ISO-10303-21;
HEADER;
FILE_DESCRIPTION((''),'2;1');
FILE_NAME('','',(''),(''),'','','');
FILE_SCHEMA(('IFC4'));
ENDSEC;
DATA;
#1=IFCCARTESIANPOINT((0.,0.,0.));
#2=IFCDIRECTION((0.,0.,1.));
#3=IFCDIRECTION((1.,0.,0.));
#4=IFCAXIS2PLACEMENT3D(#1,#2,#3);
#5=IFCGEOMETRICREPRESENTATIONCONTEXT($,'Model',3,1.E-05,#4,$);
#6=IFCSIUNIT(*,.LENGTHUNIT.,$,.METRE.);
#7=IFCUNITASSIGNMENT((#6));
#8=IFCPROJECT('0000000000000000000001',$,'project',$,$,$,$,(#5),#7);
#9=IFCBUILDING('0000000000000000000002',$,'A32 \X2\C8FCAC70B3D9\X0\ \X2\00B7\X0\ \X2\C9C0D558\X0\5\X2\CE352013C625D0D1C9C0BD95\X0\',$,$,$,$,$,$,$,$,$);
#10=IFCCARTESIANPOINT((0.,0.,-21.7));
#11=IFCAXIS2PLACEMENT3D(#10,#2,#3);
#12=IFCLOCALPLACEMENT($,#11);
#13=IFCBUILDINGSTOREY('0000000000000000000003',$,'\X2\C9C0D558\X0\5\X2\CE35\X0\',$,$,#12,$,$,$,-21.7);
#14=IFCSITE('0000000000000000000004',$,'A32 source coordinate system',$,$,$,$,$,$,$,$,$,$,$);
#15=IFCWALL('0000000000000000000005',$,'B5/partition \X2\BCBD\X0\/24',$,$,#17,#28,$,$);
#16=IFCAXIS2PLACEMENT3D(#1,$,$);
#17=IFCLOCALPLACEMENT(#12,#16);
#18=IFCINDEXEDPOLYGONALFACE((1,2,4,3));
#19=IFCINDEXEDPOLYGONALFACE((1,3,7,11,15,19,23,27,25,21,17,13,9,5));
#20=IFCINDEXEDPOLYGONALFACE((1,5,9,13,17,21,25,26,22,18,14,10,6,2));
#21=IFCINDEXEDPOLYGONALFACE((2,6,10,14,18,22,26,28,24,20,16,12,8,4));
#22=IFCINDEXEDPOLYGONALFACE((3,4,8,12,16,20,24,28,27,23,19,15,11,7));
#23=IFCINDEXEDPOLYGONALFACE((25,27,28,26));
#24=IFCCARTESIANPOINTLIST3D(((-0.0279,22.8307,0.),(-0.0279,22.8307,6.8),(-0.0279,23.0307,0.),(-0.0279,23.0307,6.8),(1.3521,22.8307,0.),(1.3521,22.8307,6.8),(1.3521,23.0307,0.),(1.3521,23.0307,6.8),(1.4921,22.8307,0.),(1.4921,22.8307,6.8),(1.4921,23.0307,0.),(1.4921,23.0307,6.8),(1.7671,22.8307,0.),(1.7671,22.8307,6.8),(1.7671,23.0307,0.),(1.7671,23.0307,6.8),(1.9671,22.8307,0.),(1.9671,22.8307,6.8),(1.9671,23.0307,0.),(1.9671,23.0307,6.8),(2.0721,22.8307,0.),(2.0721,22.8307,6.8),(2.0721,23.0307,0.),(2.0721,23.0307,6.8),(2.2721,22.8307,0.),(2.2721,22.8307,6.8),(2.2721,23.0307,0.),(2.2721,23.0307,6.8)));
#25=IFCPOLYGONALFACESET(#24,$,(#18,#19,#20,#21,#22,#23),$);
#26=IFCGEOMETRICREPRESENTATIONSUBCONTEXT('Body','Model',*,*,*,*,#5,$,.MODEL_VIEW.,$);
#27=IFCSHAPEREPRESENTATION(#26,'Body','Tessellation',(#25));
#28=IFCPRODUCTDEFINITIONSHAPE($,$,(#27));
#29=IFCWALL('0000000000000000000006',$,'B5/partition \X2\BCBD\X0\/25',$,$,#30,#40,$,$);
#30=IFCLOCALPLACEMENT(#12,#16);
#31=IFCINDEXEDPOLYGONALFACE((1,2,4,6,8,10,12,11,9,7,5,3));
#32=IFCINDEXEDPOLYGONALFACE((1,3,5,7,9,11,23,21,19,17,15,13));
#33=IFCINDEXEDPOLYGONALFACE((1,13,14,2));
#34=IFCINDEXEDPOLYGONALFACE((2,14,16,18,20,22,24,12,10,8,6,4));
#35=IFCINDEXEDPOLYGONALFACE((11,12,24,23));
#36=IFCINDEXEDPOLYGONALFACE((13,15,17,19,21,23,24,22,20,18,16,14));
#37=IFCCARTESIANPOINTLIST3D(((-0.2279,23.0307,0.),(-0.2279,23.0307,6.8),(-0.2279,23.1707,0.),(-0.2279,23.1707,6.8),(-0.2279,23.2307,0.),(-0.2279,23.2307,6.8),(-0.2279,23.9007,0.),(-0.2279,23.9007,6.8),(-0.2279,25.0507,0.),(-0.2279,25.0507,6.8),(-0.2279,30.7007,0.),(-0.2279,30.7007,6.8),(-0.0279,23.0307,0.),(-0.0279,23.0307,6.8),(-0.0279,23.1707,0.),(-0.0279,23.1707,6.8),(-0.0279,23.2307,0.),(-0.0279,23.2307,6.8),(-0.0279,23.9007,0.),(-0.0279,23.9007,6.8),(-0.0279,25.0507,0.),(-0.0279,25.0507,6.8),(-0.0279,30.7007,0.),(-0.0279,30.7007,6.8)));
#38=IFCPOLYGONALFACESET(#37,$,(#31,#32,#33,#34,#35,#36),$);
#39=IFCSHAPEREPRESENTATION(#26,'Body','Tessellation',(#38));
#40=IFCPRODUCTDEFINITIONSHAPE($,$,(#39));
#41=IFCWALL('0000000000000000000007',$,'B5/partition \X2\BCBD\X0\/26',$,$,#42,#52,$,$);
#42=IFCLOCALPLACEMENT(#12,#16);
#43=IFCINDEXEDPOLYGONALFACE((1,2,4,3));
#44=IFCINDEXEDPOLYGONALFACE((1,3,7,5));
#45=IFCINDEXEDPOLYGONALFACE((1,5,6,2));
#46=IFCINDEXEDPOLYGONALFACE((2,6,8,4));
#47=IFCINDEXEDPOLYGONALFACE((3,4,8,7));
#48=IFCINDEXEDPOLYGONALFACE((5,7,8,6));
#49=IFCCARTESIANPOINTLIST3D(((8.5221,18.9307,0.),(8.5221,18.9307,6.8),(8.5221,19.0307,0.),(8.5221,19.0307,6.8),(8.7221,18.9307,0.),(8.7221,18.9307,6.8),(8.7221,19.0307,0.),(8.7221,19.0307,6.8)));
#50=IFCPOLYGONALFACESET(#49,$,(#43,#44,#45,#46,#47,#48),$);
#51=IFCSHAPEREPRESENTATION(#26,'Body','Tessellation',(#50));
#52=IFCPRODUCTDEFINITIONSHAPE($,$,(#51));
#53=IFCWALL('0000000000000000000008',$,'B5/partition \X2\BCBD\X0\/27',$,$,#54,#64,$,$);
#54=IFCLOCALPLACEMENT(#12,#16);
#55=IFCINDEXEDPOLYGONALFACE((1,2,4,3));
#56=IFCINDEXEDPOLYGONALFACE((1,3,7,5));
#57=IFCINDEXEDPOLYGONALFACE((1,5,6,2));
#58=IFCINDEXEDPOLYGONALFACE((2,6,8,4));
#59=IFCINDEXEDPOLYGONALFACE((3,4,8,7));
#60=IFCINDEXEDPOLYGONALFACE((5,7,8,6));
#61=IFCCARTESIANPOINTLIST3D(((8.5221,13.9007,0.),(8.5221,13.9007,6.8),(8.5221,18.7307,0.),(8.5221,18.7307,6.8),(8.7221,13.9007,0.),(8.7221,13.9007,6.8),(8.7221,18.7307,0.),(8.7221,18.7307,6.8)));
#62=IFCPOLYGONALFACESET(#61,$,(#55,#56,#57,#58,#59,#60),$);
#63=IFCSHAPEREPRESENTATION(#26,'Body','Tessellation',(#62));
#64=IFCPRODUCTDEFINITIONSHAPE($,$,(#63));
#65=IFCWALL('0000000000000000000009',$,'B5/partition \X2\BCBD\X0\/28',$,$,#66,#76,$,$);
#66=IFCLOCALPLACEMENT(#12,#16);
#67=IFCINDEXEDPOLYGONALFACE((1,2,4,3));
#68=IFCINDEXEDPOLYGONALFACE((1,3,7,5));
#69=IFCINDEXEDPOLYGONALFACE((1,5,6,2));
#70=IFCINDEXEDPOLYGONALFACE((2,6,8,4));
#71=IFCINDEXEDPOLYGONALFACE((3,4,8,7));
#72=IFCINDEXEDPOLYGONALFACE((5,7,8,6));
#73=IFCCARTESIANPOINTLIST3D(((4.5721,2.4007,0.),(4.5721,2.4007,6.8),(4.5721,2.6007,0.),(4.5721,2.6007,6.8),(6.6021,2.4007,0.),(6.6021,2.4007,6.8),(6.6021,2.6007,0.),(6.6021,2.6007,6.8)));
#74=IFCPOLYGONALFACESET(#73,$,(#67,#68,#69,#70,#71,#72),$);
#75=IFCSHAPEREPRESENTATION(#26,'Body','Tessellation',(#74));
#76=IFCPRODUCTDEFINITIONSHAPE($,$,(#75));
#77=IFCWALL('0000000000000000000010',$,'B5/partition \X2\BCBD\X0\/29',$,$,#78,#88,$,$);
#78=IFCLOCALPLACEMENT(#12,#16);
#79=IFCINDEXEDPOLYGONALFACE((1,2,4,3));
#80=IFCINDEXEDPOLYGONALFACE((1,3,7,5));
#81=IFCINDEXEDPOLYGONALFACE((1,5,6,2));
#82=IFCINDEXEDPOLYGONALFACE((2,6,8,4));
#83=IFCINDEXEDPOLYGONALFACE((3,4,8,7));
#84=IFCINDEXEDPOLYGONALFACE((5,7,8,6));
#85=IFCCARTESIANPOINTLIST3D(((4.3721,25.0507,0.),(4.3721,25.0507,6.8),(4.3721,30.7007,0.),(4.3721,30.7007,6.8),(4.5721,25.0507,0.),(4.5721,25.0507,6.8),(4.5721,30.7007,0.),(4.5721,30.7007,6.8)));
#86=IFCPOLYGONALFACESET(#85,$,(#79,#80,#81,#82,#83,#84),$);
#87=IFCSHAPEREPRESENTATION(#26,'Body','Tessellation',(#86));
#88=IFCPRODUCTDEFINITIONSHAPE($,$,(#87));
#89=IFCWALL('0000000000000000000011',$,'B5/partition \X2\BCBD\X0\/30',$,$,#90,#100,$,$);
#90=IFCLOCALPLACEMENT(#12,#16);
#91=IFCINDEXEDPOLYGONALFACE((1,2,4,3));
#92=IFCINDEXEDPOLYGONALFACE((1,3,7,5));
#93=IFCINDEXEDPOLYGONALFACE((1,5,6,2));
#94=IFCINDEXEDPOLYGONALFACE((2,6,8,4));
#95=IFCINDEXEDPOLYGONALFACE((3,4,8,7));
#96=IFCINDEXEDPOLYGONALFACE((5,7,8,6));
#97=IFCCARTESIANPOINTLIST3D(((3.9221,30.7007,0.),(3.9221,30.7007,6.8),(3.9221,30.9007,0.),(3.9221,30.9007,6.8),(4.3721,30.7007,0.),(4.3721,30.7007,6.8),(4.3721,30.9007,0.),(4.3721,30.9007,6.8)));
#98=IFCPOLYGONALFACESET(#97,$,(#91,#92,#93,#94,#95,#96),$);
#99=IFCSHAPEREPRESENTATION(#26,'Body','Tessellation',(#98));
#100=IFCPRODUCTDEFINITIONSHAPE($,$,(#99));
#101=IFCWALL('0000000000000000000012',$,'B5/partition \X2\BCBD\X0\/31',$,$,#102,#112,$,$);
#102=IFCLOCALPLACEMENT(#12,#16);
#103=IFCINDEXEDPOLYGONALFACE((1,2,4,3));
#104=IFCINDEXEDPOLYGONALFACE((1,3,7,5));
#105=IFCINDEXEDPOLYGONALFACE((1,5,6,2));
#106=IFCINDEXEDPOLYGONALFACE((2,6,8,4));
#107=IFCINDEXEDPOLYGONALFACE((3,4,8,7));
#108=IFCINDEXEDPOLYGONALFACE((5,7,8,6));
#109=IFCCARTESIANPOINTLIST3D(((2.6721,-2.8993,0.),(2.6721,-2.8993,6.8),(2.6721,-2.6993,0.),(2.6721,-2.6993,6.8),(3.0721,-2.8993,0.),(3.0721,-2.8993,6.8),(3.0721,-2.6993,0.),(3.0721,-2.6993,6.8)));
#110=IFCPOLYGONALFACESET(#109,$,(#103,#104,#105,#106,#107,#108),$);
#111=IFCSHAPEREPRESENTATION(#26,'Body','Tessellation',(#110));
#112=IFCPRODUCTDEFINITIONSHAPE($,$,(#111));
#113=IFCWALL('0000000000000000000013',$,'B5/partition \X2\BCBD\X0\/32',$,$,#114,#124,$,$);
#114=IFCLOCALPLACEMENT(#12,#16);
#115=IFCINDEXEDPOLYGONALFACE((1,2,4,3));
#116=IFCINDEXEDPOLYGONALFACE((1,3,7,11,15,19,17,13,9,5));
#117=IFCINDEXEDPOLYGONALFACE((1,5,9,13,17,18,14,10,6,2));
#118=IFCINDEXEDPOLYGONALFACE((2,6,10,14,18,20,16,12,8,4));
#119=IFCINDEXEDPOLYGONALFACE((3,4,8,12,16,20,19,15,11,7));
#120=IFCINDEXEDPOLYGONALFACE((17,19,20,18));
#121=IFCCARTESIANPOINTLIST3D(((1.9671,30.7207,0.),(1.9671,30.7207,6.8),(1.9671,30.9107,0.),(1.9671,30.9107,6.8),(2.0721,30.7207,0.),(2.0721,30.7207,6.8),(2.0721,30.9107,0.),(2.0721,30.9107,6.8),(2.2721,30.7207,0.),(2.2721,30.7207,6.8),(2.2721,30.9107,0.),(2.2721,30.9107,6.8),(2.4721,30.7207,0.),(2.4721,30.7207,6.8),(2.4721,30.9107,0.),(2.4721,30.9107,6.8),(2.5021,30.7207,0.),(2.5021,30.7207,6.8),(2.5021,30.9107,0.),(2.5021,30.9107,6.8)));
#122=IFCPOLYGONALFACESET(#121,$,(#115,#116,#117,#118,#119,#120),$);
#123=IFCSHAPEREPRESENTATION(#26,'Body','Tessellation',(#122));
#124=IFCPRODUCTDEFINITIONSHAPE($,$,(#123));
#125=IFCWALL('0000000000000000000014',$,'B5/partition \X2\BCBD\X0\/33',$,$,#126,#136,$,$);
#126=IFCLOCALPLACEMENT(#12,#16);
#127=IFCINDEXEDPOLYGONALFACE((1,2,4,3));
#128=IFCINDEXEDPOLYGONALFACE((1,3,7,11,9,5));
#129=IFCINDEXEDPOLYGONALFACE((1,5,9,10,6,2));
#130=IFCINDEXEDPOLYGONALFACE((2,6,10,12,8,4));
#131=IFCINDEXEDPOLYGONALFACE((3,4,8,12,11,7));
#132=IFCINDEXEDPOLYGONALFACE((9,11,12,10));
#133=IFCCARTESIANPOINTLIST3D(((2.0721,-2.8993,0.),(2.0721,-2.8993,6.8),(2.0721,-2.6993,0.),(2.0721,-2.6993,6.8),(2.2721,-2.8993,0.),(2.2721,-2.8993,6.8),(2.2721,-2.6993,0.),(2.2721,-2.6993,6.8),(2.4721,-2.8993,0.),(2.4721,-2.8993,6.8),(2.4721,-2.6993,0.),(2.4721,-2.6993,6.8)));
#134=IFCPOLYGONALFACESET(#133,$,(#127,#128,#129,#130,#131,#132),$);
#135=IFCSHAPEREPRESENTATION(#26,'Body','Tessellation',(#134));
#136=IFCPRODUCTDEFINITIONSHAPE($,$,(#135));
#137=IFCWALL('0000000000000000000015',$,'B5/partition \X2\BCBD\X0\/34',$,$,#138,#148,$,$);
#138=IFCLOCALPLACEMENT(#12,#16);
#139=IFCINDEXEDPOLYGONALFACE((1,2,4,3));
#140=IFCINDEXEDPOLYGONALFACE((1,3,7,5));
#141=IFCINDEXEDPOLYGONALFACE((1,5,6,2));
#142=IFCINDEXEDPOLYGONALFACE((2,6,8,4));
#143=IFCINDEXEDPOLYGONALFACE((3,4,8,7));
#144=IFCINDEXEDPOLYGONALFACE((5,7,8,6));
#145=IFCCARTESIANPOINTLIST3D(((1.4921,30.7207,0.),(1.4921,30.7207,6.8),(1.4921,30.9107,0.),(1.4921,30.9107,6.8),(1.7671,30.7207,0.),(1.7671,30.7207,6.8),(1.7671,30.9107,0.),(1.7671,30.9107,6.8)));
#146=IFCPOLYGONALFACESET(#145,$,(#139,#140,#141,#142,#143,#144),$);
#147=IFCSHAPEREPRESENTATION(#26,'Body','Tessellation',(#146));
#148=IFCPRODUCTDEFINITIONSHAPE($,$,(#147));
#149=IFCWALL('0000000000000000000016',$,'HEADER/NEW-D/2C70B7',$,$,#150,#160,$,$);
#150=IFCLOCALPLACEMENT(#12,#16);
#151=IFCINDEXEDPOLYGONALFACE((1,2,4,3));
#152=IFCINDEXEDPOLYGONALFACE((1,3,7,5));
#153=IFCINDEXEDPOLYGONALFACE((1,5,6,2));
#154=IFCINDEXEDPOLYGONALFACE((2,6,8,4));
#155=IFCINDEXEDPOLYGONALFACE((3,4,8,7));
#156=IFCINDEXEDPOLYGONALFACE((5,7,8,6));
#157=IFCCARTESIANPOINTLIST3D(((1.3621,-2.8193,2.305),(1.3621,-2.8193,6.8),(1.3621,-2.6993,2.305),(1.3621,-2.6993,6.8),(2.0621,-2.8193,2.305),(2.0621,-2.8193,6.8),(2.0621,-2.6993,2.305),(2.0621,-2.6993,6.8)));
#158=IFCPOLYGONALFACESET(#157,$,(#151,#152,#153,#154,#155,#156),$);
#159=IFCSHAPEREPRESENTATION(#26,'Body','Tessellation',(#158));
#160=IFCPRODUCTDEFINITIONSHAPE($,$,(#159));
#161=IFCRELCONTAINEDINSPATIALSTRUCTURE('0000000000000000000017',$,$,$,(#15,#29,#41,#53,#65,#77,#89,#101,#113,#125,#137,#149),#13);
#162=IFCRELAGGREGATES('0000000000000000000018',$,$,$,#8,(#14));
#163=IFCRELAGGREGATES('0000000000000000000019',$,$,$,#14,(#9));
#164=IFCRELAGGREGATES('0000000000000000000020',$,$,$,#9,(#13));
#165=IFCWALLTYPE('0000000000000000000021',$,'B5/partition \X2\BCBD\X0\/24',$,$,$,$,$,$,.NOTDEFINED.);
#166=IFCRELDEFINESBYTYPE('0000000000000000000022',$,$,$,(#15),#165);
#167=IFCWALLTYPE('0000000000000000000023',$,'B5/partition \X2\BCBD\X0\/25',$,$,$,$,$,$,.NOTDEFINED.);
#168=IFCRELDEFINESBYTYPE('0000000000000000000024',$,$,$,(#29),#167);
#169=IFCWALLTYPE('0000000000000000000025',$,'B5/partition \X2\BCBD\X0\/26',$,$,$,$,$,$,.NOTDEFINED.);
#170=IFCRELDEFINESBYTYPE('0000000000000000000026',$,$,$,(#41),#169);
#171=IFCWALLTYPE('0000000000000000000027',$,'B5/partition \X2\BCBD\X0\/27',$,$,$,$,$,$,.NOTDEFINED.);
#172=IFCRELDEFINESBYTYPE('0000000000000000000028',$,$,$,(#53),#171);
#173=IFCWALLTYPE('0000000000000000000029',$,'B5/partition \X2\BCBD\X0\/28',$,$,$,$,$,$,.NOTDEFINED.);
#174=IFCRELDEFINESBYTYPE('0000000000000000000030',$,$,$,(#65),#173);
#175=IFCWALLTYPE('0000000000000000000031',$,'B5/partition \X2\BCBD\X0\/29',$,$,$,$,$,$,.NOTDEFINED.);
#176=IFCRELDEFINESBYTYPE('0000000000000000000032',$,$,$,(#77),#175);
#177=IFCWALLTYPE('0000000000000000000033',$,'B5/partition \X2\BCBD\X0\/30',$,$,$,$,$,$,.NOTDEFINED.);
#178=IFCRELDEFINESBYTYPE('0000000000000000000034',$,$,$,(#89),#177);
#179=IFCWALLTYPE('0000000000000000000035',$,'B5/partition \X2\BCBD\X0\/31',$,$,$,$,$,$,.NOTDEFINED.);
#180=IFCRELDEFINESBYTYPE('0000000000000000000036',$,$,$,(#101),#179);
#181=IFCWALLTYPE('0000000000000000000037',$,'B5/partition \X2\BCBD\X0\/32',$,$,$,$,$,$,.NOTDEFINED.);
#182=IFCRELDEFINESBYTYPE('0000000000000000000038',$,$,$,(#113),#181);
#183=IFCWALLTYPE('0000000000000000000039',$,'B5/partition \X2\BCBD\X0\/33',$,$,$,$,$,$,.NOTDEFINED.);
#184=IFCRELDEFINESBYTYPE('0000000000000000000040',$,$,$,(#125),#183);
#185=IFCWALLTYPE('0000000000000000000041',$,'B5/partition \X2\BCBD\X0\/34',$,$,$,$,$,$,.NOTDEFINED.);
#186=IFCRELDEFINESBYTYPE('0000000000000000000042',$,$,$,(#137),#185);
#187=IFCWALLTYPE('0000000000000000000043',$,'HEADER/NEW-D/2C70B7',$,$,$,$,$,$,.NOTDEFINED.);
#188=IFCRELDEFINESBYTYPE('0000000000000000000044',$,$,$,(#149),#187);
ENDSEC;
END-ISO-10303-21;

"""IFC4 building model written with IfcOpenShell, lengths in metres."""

from ifc_helpers import new_model, si_unit, frame, origin, origin_with_axes, place, context, subcontext, project, spatial, polyline, outline, extrude, source, transform, mapped, type_object, type_shapes, element, save


model = new_model("IFC4")

# Units and contexts
model_context = context("Model", 3, precision=1e-05, world=origin_with_axes())
body_context = subcontext(model_context, "Body", "Model", "MODEL_VIEW")
ifc_project = project(units=[si_unit("LENGTHUNIT", "METRE")], contexts=[model_context])

# Site, building, storey
site = spatial("IfcSite", under=ifc_project, Name="A32 source coordinate system")
building = spatial("IfcBuilding", under=site, Name="A32 주거동 · 지하5층–옥탑지붕")
storey_placement = place(None, frame((0.0, 0.0, -21.7), z_axis=(0.0, 0.0, 1.0), x_axis=(1.0, 0.0, 0.0)))
storey = spatial("IfcBuildingStorey", under=building, at=storey_placement, Name="지하5층", Elevation=-21.7)

# Walls
wall_type_1 = type_object("IfcWallType", Name="B5/partition 벽/24", PredefinedType="NOTDEFINED")
shared_shape_1 = source(origin(), body_context, "Body", "SweptSolid", [
    extrude(outline(polyline([(-0.0279, 23.0307), (1.3521, 23.0307), (1.4921, 23.0307), (1.7671, 23.0307), (1.9671, 23.0307), (2.0721, 23.0307), (2.2721, 23.0307), (2.2721, 22.8307), (2.0721, 22.8307), (1.9671, 22.8307), (1.7671, 22.8307), (1.4921, 22.8307), (1.3521, 22.8307), (-0.0279, 22.8307), (-0.0279, 23.0307)])), origin(), (0.0, 0.0, 1.0), 6.8),
])
type_shapes(wall_type_1, [shared_shape_1])
wall_1_placement = place(storey_placement, origin_with_axes())
element("IfcWall", 1, at=wall_1_placement, inside=storey, type_object=wall_type_1, Name="B5/partition 벽/24", context=body_context, shape_type="MappedRepresentation", body=[
    mapped(shared_shape_1, transform((0.0, 0.0, 0.0), scale=1.0)),
])
wall_type_2 = type_object("IfcWallType", Name="B5/partition 벽/25", PredefinedType="NOTDEFINED")
shared_shape_2 = source(origin(), body_context, "Body", "SweptSolid", [
    extrude(outline(polyline([(-0.2279, 23.0307), (-0.2279, 23.1707), (-0.2279, 23.2307), (-0.2279, 23.9007), (-0.2279, 25.0507), (-0.2279, 30.7007), (-0.0279, 30.7007), (-0.0279, 25.0507), (-0.0279, 23.9007), (-0.0279, 23.2307), (-0.0279, 23.1707), (-0.0279, 23.0307), (-0.2279, 23.0307)])), origin(), (0.0, 0.0, 1.0), 6.8),
])
type_shapes(wall_type_2, [shared_shape_2])
wall_2_placement = place(storey_placement, origin_with_axes())
element("IfcWall", 2, at=wall_2_placement, inside=storey, type_object=wall_type_2, Name="B5/partition 벽/25", context=body_context, shape_type="MappedRepresentation", body=[
    mapped(shared_shape_2, transform((0.0, 0.0, 0.0), scale=1.0)),
])
wall_type_3 = type_object("IfcWallType", Name="B5/partition 벽/26", PredefinedType="NOTDEFINED")
shared_shape_3 = source(origin(), body_context, "Body", "SweptSolid", [
    extrude(outline(polyline([(8.5221, 19.0307), (8.7221, 19.0307), (8.7221, 18.9307), (8.5221, 18.9307), (8.5221, 19.0307)])), origin(), (0.0, 0.0, 1.0), 6.8),
])
type_shapes(wall_type_3, [shared_shape_3])
wall_3_placement = place(storey_placement, origin_with_axes())
element("IfcWall", 3, at=wall_3_placement, inside=storey, type_object=wall_type_3, Name="B5/partition 벽/26", context=body_context, shape_type="MappedRepresentation", body=[
    mapped(shared_shape_3, transform((0.0, 0.0, 0.0), scale=1.0)),
])
wall_type_4 = type_object("IfcWallType", Name="B5/partition 벽/27", PredefinedType="NOTDEFINED")
shared_shape_4 = source(origin(), body_context, "Body", "SweptSolid", [
    extrude(outline(polyline([(8.7221, 18.7307), (8.7221, 13.9007), (8.5221, 13.9007), (8.5221, 18.7307), (8.7221, 18.7307)])), origin(), (0.0, 0.0, 1.0), 6.8),
])
type_shapes(wall_type_4, [shared_shape_4])
wall_4_placement = place(storey_placement, origin_with_axes())
element("IfcWall", 4, at=wall_4_placement, inside=storey, type_object=wall_type_4, Name="B5/partition 벽/27", context=body_context, shape_type="MappedRepresentation", body=[
    mapped(shared_shape_4, transform((0.0, 0.0, 0.0), scale=1.0)),
])
wall_type_5 = type_object("IfcWallType", Name="B5/partition 벽/28", PredefinedType="NOTDEFINED")
shared_shape_5 = source(origin(), body_context, "Body", "SweptSolid", [
    extrude(outline(polyline([(6.6021, 2.6007), (6.6021, 2.4007), (4.5721, 2.4007), (4.5721, 2.6007), (6.6021, 2.6007)])), origin(), (0.0, 0.0, 1.0), 6.8),
])
type_shapes(wall_type_5, [shared_shape_5])
wall_5_placement = place(storey_placement, origin_with_axes())
element("IfcWall", 5, at=wall_5_placement, inside=storey, type_object=wall_type_5, Name="B5/partition 벽/28", context=body_context, shape_type="MappedRepresentation", body=[
    mapped(shared_shape_5, transform((0.0, 0.0, 0.0), scale=1.0)),
])
wall_type_6 = type_object("IfcWallType", Name="B5/partition 벽/29", PredefinedType="NOTDEFINED")
shared_shape_6 = source(origin(), body_context, "Body", "SweptSolid", [
    extrude(outline(polyline([(4.5721, 30.7007), (4.5721, 25.0507), (4.3721, 25.0507), (4.3721, 30.7007), (4.5721, 30.7007)])), origin(), (0.0, 0.0, 1.0), 6.8),
])
type_shapes(wall_type_6, [shared_shape_6])
wall_6_placement = place(storey_placement, origin_with_axes())
element("IfcWall", 6, at=wall_6_placement, inside=storey, type_object=wall_type_6, Name="B5/partition 벽/29", context=body_context, shape_type="MappedRepresentation", body=[
    mapped(shared_shape_6, transform((0.0, 0.0, 0.0), scale=1.0)),
])
wall_type_7 = type_object("IfcWallType", Name="B5/partition 벽/30", PredefinedType="NOTDEFINED")
shared_shape_7 = source(origin(), body_context, "Body", "SweptSolid", [
    extrude(outline(polyline([(3.9221, 30.7007), (3.9221, 30.9007), (4.3721, 30.9007), (4.3721, 30.7007), (3.9221, 30.7007)])), origin(), (0.0, 0.0, 1.0), 6.8),
])
type_shapes(wall_type_7, [shared_shape_7])
wall_7_placement = place(storey_placement, origin_with_axes())
element("IfcWall", 7, at=wall_7_placement, inside=storey, type_object=wall_type_7, Name="B5/partition 벽/30", context=body_context, shape_type="MappedRepresentation", body=[
    mapped(shared_shape_7, transform((0.0, 0.0, 0.0), scale=1.0)),
])
wall_type_8 = type_object("IfcWallType", Name="B5/partition 벽/31", PredefinedType="NOTDEFINED")
shared_shape_8 = source(origin(), body_context, "Body", "SweptSolid", [
    extrude(outline(polyline([(2.6721, -2.8993), (2.6721, -2.6993), (3.0721, -2.6993), (3.0721, -2.8993), (2.6721, -2.8993)])), origin(), (0.0, 0.0, 1.0), 6.8),
])
type_shapes(wall_type_8, [shared_shape_8])
wall_8_placement = place(storey_placement, origin_with_axes())
element("IfcWall", 8, at=wall_8_placement, inside=storey, type_object=wall_type_8, Name="B5/partition 벽/31", context=body_context, shape_type="MappedRepresentation", body=[
    mapped(shared_shape_8, transform((0.0, 0.0, 0.0), scale=1.0)),
])
wall_type_9 = type_object("IfcWallType", Name="B5/partition 벽/32", PredefinedType="NOTDEFINED")
shared_shape_9 = source(origin(), body_context, "Body", "SweptSolid", [
    extrude(outline(polyline([(2.0721, 30.7207), (1.9671, 30.7207), (1.9671, 30.9107), (2.0721, 30.9107), (2.2721, 30.9107), (2.4721, 30.9107), (2.5021, 30.9107), (2.5021, 30.7207), (2.4721, 30.7207), (2.2721, 30.7207), (2.0721, 30.7207)])), origin(), (0.0, 0.0, 1.0), 6.8),
])
type_shapes(wall_type_9, [shared_shape_9])
wall_9_placement = place(storey_placement, origin_with_axes())
element("IfcWall", 9, at=wall_9_placement, inside=storey, type_object=wall_type_9, Name="B5/partition 벽/32", context=body_context, shape_type="MappedRepresentation", body=[
    mapped(shared_shape_9, transform((0.0, 0.0, 0.0), scale=1.0)),
])
wall_type_10 = type_object("IfcWallType", Name="B5/partition 벽/33", PredefinedType="NOTDEFINED")
shared_shape_10 = source(origin(), body_context, "Body", "SweptSolid", [
    extrude(outline(polyline([(2.2721, -2.8993), (2.0721, -2.8993), (2.0721, -2.6993), (2.2721, -2.6993), (2.4721, -2.6993), (2.4721, -2.8993), (2.2721, -2.8993)])), origin(), (0.0, 0.0, 1.0), 6.8),
])
type_shapes(wall_type_10, [shared_shape_10])
wall_10_placement = place(storey_placement, origin_with_axes())
element("IfcWall", 10, at=wall_10_placement, inside=storey, type_object=wall_type_10, Name="B5/partition 벽/33", context=body_context, shape_type="MappedRepresentation", body=[
    mapped(shared_shape_10, transform((0.0, 0.0, 0.0), scale=1.0)),
])
wall_type_11 = type_object("IfcWallType", Name="B5/partition 벽/34", PredefinedType="NOTDEFINED")
shared_shape_11 = source(origin(), body_context, "Body", "SweptSolid", [
    extrude(outline(polyline([(1.4921, 30.7207), (1.4921, 30.9107), (1.7671, 30.9107), (1.7671, 30.7207), (1.4921, 30.7207)])), origin(), (0.0, 0.0, 1.0), 6.8),
])
type_shapes(wall_type_11, [shared_shape_11])
wall_11_placement = place(storey_placement, origin_with_axes())
element("IfcWall", 11, at=wall_11_placement, inside=storey, type_object=wall_type_11, Name="B5/partition 벽/34", context=body_context, shape_type="MappedRepresentation", body=[
    mapped(shared_shape_11, transform((0.0, 0.0, 0.0), scale=1.0)),
])
wall_type_12 = type_object("IfcWallType", Name="HEADER/NEW-D/2C70B7", PredefinedType="NOTDEFINED")
shared_shape_12 = source(origin(), body_context, "Body", "SweptSolid", [
    extrude(outline(polyline([(1.3621, -2.8193), (1.3621, -2.6993), (2.0621, -2.6993), (2.0621, -2.8193), (1.3621, -2.8193)])), frame((0.0, 0.0, 2.305)), (0.0, 0.0, 1.0), 4.495),
])
type_shapes(wall_type_12, [shared_shape_12])
wall_12_placement = place(storey_placement, origin_with_axes())
element("IfcWall", 12, at=wall_12_placement, inside=storey, type_object=wall_type_12, Name="HEADER/NEW-D/2C70B7", context=body_context, shape_type="MappedRepresentation", body=[
    mapped(shared_shape_12, transform((0.0, 0.0, 0.0), scale=1.0)),
])

save(model, "model.ifc")
